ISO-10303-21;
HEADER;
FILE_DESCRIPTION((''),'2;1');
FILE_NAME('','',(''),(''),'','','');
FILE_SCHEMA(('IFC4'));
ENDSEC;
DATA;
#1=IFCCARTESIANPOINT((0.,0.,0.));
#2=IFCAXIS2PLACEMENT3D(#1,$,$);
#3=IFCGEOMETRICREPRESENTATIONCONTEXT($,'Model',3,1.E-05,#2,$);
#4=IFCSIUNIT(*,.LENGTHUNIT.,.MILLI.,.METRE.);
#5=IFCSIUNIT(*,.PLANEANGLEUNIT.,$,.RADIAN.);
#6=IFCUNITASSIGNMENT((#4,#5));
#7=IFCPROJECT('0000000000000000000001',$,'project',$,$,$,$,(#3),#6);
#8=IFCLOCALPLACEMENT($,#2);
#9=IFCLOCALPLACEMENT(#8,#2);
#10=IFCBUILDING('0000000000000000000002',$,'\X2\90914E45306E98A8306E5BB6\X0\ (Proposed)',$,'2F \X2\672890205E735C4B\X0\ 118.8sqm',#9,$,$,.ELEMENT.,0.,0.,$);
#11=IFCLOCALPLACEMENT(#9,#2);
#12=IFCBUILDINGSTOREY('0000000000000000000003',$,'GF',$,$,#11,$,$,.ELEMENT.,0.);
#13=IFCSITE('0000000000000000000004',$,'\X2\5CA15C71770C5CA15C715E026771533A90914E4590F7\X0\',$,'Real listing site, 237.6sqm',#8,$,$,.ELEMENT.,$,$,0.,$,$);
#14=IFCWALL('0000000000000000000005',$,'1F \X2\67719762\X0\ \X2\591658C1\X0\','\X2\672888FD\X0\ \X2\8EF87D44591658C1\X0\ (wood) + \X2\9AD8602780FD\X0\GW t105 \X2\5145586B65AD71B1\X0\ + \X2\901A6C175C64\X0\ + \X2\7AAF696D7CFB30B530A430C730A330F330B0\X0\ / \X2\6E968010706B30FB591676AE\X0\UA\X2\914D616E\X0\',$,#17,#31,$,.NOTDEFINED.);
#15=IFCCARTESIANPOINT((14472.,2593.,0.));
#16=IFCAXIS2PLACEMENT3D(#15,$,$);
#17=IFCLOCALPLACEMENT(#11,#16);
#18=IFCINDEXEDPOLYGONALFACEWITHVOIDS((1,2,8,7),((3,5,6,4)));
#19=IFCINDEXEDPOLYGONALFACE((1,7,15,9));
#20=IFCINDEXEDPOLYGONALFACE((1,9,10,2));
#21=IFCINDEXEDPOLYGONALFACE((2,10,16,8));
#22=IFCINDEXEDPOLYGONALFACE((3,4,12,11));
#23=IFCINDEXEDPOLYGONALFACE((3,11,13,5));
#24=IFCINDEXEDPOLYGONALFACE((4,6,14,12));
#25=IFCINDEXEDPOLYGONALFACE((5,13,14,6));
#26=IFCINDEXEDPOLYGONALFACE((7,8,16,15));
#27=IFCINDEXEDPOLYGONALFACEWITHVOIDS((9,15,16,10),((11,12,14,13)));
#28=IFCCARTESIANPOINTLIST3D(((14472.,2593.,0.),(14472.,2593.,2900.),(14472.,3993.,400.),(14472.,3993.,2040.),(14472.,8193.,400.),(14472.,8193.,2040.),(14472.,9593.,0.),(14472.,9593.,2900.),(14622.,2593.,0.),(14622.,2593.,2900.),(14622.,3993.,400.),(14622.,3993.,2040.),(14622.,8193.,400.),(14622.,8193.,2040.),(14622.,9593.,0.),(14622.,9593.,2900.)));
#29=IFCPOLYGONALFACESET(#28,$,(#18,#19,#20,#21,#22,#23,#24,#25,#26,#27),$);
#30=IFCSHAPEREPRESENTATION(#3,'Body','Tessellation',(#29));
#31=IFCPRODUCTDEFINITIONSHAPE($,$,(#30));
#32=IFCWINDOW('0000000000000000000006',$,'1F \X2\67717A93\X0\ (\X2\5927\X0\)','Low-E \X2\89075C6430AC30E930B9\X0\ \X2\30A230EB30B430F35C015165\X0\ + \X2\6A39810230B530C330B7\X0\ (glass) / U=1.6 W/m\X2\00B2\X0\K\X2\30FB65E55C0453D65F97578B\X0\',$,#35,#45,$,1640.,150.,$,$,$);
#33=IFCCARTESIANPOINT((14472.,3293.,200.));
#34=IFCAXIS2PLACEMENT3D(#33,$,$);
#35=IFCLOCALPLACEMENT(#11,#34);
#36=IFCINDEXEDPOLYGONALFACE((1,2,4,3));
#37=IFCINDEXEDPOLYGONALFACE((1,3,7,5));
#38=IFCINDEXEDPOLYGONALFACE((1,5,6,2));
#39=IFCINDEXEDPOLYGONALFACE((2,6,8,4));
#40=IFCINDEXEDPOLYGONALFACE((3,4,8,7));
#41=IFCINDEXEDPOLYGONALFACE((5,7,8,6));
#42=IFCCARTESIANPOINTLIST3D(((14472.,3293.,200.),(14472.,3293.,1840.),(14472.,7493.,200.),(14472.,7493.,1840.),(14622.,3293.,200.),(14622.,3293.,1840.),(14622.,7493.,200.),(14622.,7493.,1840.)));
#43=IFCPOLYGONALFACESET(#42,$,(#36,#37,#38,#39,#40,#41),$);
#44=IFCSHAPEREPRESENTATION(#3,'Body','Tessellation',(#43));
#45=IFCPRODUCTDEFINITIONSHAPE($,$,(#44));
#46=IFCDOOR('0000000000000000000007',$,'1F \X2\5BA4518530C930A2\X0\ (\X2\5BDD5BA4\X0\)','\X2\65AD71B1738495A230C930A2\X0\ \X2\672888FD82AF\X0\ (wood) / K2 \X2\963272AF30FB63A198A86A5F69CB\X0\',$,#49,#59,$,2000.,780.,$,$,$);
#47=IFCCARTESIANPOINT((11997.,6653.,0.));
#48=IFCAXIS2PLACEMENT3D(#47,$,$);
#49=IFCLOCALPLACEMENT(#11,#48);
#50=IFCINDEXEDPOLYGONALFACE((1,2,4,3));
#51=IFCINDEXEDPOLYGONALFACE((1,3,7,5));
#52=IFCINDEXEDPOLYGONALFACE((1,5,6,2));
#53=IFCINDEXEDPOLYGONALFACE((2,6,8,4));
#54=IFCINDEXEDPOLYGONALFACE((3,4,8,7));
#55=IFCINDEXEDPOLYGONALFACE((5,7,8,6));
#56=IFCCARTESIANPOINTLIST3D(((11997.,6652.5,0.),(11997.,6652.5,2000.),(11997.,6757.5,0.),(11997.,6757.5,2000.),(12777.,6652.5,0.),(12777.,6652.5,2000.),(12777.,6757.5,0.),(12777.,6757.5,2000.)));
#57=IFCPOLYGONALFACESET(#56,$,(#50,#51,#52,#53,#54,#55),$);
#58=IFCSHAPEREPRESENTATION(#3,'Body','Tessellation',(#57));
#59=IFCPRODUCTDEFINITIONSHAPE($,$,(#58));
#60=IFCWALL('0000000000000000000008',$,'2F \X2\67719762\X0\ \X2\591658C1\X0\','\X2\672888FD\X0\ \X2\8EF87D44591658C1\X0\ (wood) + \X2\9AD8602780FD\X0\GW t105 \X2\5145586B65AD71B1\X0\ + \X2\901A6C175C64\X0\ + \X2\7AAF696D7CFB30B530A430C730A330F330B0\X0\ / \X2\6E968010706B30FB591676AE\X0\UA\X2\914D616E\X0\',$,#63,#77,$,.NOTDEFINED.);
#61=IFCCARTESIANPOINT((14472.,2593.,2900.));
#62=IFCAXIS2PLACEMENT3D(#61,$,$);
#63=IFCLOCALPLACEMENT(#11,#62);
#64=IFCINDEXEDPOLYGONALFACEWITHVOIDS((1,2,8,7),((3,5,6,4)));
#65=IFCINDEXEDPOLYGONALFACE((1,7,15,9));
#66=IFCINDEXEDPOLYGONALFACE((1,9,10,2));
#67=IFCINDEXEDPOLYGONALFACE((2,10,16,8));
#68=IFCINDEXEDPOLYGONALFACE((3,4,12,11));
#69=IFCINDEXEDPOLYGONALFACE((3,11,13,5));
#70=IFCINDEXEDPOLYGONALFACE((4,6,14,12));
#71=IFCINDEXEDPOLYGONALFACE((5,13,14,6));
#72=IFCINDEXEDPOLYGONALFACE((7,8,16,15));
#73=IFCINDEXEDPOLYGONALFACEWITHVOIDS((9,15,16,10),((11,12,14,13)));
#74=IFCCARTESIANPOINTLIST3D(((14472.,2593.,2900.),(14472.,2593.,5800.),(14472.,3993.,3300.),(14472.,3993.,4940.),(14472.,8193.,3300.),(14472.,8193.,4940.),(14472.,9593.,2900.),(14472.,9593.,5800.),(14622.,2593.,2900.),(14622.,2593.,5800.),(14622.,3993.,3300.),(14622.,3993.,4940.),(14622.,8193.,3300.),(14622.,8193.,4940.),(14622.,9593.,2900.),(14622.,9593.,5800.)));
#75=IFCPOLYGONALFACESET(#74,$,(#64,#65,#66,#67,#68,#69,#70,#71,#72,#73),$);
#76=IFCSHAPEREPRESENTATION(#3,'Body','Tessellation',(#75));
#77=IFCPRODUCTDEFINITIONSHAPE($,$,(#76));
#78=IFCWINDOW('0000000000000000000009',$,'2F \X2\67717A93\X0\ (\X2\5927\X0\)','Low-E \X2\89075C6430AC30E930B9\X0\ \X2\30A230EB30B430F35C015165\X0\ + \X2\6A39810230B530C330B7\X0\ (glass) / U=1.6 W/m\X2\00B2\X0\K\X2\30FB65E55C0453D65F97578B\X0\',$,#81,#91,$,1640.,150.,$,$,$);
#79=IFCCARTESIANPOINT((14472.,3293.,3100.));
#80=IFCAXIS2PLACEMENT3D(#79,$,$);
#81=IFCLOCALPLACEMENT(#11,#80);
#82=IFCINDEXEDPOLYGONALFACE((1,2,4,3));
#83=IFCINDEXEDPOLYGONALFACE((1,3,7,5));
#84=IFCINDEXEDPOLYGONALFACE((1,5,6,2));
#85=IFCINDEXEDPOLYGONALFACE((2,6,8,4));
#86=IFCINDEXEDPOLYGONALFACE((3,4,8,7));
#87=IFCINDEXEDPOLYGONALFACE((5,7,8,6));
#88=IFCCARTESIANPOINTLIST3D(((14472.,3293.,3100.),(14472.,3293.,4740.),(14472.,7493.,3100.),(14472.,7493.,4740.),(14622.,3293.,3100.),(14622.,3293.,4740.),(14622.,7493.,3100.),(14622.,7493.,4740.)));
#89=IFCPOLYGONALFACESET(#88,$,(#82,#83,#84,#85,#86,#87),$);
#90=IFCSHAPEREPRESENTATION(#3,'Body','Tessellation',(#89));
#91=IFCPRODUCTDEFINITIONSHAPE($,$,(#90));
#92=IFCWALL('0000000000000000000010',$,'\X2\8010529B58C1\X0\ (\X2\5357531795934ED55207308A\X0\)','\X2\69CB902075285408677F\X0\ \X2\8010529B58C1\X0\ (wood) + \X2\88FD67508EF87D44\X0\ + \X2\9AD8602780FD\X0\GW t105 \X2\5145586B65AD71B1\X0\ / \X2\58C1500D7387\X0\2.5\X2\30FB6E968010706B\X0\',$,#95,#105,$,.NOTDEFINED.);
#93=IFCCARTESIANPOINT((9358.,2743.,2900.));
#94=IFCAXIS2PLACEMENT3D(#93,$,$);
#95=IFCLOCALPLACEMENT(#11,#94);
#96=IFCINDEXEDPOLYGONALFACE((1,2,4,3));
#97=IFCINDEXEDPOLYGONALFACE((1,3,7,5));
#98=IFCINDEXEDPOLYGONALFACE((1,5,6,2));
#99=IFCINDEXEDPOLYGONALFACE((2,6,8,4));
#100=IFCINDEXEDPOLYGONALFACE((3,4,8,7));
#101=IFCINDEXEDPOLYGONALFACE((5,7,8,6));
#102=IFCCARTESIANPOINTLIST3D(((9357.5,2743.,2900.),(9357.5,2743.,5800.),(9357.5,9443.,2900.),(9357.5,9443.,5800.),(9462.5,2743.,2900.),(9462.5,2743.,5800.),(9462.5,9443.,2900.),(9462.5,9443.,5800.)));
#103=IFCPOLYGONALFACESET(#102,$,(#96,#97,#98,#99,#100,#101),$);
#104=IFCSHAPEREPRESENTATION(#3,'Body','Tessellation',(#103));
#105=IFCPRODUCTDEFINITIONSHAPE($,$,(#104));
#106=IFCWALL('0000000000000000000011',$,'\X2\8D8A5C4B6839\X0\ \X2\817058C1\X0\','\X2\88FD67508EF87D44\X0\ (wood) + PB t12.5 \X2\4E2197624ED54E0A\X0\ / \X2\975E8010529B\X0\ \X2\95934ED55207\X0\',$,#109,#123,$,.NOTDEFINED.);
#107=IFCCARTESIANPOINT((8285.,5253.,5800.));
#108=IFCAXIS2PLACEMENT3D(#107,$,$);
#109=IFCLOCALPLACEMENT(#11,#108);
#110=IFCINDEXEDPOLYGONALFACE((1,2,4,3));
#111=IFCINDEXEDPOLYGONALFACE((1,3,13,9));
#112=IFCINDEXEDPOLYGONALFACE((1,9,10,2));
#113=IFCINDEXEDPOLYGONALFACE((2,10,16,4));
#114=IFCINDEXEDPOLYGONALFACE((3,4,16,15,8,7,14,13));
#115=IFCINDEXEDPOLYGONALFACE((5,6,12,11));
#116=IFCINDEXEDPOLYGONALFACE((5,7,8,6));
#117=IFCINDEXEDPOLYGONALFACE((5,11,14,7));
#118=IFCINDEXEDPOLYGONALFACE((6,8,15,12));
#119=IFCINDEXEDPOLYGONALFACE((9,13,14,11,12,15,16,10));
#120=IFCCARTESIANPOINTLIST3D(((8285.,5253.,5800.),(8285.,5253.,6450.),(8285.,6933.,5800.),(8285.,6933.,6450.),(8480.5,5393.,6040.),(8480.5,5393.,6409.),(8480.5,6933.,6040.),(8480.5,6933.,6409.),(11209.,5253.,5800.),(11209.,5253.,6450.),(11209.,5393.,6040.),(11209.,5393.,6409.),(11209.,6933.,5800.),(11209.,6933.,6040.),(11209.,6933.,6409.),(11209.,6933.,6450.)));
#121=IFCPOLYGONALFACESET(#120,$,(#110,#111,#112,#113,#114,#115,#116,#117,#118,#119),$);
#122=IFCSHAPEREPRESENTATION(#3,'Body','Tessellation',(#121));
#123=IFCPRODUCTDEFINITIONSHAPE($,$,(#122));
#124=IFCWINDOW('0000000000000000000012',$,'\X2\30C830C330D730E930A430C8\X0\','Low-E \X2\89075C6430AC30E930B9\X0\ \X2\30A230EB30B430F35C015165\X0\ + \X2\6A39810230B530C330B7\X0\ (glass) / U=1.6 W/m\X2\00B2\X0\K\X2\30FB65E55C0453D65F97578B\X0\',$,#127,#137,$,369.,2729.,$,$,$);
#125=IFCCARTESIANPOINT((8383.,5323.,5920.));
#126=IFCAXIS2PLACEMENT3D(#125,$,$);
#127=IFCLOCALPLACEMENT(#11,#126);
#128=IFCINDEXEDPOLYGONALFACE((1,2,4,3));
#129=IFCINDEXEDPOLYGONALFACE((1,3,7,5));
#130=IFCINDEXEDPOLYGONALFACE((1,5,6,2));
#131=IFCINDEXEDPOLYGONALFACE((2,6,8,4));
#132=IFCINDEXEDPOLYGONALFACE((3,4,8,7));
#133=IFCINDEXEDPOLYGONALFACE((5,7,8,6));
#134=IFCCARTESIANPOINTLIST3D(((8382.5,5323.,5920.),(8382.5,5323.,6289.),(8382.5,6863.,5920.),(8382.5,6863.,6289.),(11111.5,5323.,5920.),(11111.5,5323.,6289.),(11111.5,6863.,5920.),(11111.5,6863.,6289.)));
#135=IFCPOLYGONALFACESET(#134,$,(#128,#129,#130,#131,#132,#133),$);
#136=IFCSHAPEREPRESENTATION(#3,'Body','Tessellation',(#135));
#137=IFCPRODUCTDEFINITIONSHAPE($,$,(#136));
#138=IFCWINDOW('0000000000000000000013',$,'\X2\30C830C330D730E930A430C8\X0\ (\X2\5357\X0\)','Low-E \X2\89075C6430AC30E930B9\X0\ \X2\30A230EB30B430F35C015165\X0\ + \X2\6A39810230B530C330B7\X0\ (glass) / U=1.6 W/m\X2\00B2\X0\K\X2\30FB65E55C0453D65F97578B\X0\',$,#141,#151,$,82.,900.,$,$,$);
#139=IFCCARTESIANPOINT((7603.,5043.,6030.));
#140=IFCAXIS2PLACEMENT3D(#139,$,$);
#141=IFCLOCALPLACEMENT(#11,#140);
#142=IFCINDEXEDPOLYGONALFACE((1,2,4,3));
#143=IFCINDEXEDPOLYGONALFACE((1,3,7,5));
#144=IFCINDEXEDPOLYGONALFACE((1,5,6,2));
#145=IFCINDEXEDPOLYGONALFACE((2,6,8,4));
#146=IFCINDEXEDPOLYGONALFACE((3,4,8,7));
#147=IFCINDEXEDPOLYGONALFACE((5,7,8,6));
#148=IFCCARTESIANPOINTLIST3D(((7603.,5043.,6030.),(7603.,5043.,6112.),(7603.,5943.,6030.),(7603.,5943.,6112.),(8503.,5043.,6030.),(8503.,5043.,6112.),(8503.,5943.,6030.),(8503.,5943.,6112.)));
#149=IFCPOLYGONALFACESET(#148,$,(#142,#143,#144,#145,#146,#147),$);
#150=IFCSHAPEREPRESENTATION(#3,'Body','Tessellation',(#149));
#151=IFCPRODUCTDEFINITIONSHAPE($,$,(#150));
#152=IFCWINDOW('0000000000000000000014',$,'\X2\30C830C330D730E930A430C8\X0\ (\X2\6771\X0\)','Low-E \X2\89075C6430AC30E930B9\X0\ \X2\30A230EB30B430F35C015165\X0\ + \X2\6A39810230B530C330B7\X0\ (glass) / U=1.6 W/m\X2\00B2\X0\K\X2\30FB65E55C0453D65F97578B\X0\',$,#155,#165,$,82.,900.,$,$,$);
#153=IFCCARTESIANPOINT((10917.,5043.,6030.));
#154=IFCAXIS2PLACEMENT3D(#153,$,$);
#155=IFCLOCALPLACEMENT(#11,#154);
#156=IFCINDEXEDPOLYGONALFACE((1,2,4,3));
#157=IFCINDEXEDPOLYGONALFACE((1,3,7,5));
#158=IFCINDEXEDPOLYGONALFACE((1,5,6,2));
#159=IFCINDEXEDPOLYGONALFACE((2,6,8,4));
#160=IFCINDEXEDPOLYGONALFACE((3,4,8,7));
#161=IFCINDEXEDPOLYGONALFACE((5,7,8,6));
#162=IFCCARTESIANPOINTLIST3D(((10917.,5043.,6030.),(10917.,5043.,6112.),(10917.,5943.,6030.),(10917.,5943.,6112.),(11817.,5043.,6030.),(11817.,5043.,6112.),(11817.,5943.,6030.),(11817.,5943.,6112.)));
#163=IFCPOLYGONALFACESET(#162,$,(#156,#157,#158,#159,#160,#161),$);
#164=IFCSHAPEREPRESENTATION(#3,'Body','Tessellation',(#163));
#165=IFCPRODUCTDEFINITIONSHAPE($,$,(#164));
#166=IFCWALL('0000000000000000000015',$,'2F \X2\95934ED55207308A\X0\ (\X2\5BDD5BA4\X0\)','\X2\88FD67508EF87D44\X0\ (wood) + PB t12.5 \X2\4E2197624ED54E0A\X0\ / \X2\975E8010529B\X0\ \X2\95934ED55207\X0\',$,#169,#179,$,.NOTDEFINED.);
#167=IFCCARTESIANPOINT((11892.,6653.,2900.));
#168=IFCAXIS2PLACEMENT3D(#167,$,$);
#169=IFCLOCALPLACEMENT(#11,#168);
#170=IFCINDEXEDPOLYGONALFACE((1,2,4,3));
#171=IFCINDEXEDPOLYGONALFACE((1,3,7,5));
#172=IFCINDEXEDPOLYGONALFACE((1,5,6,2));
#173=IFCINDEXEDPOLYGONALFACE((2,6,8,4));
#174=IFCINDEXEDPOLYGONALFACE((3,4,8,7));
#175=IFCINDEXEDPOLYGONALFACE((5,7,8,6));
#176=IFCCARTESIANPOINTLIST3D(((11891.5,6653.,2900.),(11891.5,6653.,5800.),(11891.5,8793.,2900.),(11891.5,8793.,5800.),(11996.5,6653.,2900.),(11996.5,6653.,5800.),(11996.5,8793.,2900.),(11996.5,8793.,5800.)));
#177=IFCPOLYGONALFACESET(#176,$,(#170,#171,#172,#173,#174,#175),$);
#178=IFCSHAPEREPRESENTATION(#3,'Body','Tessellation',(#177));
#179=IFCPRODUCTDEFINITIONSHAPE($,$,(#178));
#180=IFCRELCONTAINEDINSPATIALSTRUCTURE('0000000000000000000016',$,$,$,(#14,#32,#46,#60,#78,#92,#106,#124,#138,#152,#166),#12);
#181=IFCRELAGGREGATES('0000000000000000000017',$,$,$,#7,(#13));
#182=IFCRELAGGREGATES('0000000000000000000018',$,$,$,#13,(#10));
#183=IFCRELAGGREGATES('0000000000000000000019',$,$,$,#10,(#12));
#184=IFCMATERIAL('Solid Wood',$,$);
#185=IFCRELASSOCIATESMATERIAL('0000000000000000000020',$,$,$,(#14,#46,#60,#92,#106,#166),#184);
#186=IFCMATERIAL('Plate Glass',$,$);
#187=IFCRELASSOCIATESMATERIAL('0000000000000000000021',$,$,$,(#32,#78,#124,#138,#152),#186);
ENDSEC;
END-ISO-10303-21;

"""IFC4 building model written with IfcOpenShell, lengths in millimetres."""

from ifc_helpers import new_model, si_unit, frame, frame_2d, origin, place, context, project, spatial, rectangle, extrude, material, element, fill, save


model = new_model("IFC4")

# Units and contexts
model_context = context("Model", 3, precision=1e-05, world=origin())
ifc_project = project(units=[si_unit("LENGTHUNIT", "METRE", prefix="MILLI"), si_unit("PLANEANGLEUNIT", "RADIAN")], contexts=[model_context])

# Site, building, storey
site_placement = place(None, origin())
site = spatial("IfcSite", under=ifc_project, at=site_placement, Name="岡山県岡山市東区邑久郷", ObjectType="Real listing site, 237.6sqm", CompositionType="ELEMENT", RefElevation=0.0)
building_placement = place(site_placement, origin())
building = spatial("IfcBuilding", under=site, at=building_placement, Name="邑久の風の家 (Proposed)", ObjectType="2F 木造平屋 118.8sqm", CompositionType="ELEMENT", ElevationOfRefHeight=0.0, ElevationOfTerrain=0.0)
storey_placement = place(building_placement, origin())
storey = spatial("IfcBuildingStorey", under=building, at=storey_placement, Name="GF", CompositionType="ELEMENT", Elevation=0.0)

# Wall, opening, window
ifc_material_1 = material(Name="Solid Wood")
wall_1_placement = place(storey_placement, frame((14472.0, 2593.0, 0.0)))
wall_1 = element("IfcWall", 1, at=wall_1_placement, inside=storey, material=ifc_material_1, Name="1F 東面 外壁", Description="木製 軸組外壁 (wood) + 高性能GW t105 充填断熱 + 通気層 + 窯業系サイディング / 準耐火・外皮UA配慮", PredefinedType="NOTDEFINED", context=model_context, shape_type="SweptSolid", body=[
    extrude(rectangle(XDim=150.0, YDim=7000.0, at=frame_2d((75.0, 3500.0))), frame((14472.0, 2593.0, 0.0)), (0.0, 0.0, 1.0), 2900.0),
])
opening_1_placement = place(storey_placement, frame((14472.0, 3293.0, 200.0)))
opening_1 = element("IfcOpeningElement", 2, at=opening_1_placement, cuts=wall_1, PredefinedType="NOTDEFINED", context=model_context, shape_type="SweptSolid", body=[
    extrude(rectangle(XDim=150.0, YDim=4200.0, at=frame_2d((75.0, 2100.0))), frame((14472.0, 3293.0, 200.0)), (0.0, 0.0, 1.0), 1640.0),
])
ifc_material_2 = material(Name="Plate Glass")
window_1_placement = place(storey_placement, frame((14472.0, 3293.0, 200.0)))
window_1 = element("IfcWindow", 3, at=window_1_placement, inside=storey, material=ifc_material_2, Name="1F 東窓 (大)", Description="Low-E 複層ガラス アルゴン封入 + 樹脂サッシ (glass) / U=1.6 W/m²K・日射取得型", OverallHeight=1640.0, OverallWidth=150.0, context=model_context, shape_type="SweptSolid", body=[
    extrude(rectangle(XDim=150.0, YDim=4200.0, at=frame_2d((75.0, 2100.0))), frame((14472.0, 3293.0, 200.0)), (0.0, 0.0, 1.0), 1640.0),
])
fill(opening_1, window_1)

# Door
door_1_placement = place(storey_placement, frame((11997.0, 6653.0, 0.0)))
element("IfcDoor", 4, at=door_1_placement, inside=storey, material=ifc_material_1, Name="1F 室内ドア (寝室)", Description="断熱玄関ドア 木製芯 (wood) / K2 防犯・採風機構", OverallHeight=2000.0, OverallWidth=780.0, context=model_context, shape_type="SweptSolid", body=[
    extrude(rectangle(XDim=780.0, YDim=105.0, at=frame_2d((390.0, 52.0))), frame((11997.0, 6653.0, 0.0)), (0.0, 0.0, 1.0), 2000.0),
])

# Wall, opening, window
wall_2_placement = place(storey_placement, frame((14472.0, 2593.0, 2900.0)))
wall_2 = element("IfcWall", 5, at=wall_2_placement, inside=storey, material=ifc_material_1, Name="2F 東面 外壁", Description="木製 軸組外壁 (wood) + 高性能GW t105 充填断熱 + 通気層 + 窯業系サイディング / 準耐火・外皮UA配慮", PredefinedType="NOTDEFINED", context=model_context, shape_type="SweptSolid", body=[
    extrude(rectangle(XDim=150.0, YDim=7000.0, at=frame_2d((75.0, 3500.0))), frame((14472.0, 2593.0, 2900.0)), (0.0, 0.0, 1.0), 2900.0),
])
opening_2_placement = place(storey_placement, frame((14472.0, 3293.0, 3100.0)))
opening_2 = element("IfcOpeningElement", 6, at=opening_2_placement, cuts=wall_2, PredefinedType="NOTDEFINED", context=model_context, shape_type="SweptSolid", body=[
    extrude(rectangle(XDim=150.0, YDim=4200.0, at=frame_2d((75.0, 2100.0))), frame((14472.0, 3293.0, 3100.0)), (0.0, 0.0, 1.0), 1640.0),
])
window_2_placement = place(storey_placement, frame((14472.0, 3293.0, 3100.0)))
window_2 = element("IfcWindow", 7, at=window_2_placement, inside=storey, material=ifc_material_2, Name="2F 東窓 (大)", Description="Low-E 複層ガラス アルゴン封入 + 樹脂サッシ (glass) / U=1.6 W/m²K・日射取得型", OverallHeight=1640.0, OverallWidth=150.0, context=model_context, shape_type="SweptSolid", body=[
    extrude(rectangle(XDim=150.0, YDim=4200.0, at=frame_2d((75.0, 2100.0))), frame((14472.0, 3293.0, 3100.0)), (0.0, 0.0, 1.0), 1640.0),
])
fill(opening_2, window_2)

# Wall
wall_3_placement = place(storey_placement, frame((9358.0, 2743.0, 2900.0)))
element("IfcWall", 8, at=wall_3_placement, inside=storey, material=ifc_material_1, Name="耐力壁 (南北間仕切り)", Description="構造用合板 耐力壁 (wood) + 製材軸組 + 高性能GW t105 充填断熱 / 壁倍率2.5・準耐火", PredefinedType="NOTDEFINED", context=model_context, shape_type="SweptSolid", body=[
    extrude(rectangle(XDim=105.0, YDim=6700.0, at=frame_2d((52.0, 3350.0))), frame((9358.0, 2743.0, 2900.0)), (0.0, 0.0, 1.0), 2900.0),
])

# Wall, openings, windows
wall_4_placement = place(storey_placement, frame((8285.0, 5253.0, 5800.0)))
wall_4 = element("IfcWall", 9, at=wall_4_placement, inside=storey, material=ifc_material_1, Name="越屋根 腰壁", Description="製材軸組 (wood) + PB t12.5 両面仕上 / 非耐力 間仕切", PredefinedType="NOTDEFINED", context=model_context, shape_type="SweptSolid", body=[
    extrude(rectangle(XDim=2924.0, YDim=1680.0, at=frame_2d((1462.0, 840.0))), frame((8285.0, 5253.0, 5800.0)), (0.0, 0.0, 1.0), 650.0),
])
opening_3_placement = place(storey_placement, frame((8383.0, 5323.0, 5920.0)))
opening_3 = element("IfcOpeningElement", 10, at=opening_3_placement, cuts=wall_4, PredefinedType="NOTDEFINED", context=model_context, shape_type="SweptSolid", body=[
    extrude(rectangle(XDim=2729.0, YDim=1540.0, at=frame_2d((1364.0, 770.0))), frame((8383.0, 5323.0, 5920.0)), (0.0, 0.0, 1.0), 369.0),
])
opening_4_placement = place(storey_placement, frame((7603.0, 5043.0, 6030.0)))
opening_4 = element("IfcOpeningElement", 11, at=opening_4_placement, cuts=wall_4, PredefinedType="NOTDEFINED", context=model_context, shape_type="SweptSolid", body=[
    extrude(rectangle(XDim=900.0, YDim=900.0, at=frame_2d((450.0, 450.0))), frame((7603.0, 5043.0, 6030.0)), (0.0, 0.0, 1.0), 82.0),
])
opening_5_placement = place(storey_placement, frame((10917.0, 5043.0, 6030.0)))
opening_5 = element("IfcOpeningElement", 12, at=opening_5_placement, cuts=wall_4, PredefinedType="NOTDEFINED", context=model_context, shape_type="SweptSolid", body=[
    extrude(rectangle(XDim=900.0, YDim=900.0, at=frame_2d((450.0, 450.0))), frame((10917.0, 5043.0, 6030.0)), (0.0, 0.0, 1.0), 82.0),
])
window_3_placement = place(storey_placement, frame((8383.0, 5323.0, 5920.0)))
window_3 = element("IfcWindow", 13, at=window_3_placement, inside=storey, material=ifc_material_2, Name="トップライト", Description="Low-E 複層ガラス アルゴン封入 + 樹脂サッシ (glass) / U=1.6 W/m²K・日射取得型", OverallHeight=369.0, OverallWidth=2729.0, context=model_context, shape_type="SweptSolid", body=[
    extrude(rectangle(XDim=2729.0, YDim=1540.0, at=frame_2d((1364.0, 770.0))), frame((8383.0, 5323.0, 5920.0)), (0.0, 0.0, 1.0), 369.0),
])
fill(opening_3, window_3)
window_4_placement = place(storey_placement, frame((7603.0, 5043.0, 6030.0)))
window_4 = element("IfcWindow", 14, at=window_4_placement, inside=storey, material=ifc_material_2, Name="トップライト (南)", Description="Low-E 複層ガラス アルゴン封入 + 樹脂サッシ (glass) / U=1.6 W/m²K・日射取得型", OverallHeight=82.0, OverallWidth=900.0, context=model_context, shape_type="SweptSolid", body=[
    extrude(rectangle(XDim=900.0, YDim=900.0, at=frame_2d((450.0, 450.0))), frame((7603.0, 5043.0, 6030.0)), (0.0, 0.0, 1.0), 82.0),
])
fill(opening_4, window_4)
window_5_placement = place(storey_placement, frame((10917.0, 5043.0, 6030.0)))
window_5 = element("IfcWindow", 15, at=window_5_placement, inside=storey, material=ifc_material_2, Name="トップライト (東)", Description="Low-E 複層ガラス アルゴン封入 + 樹脂サッシ (glass) / U=1.6 W/m²K・日射取得型", OverallHeight=82.0, OverallWidth=900.0, context=model_context, shape_type="SweptSolid", body=[
    extrude(rectangle(XDim=900.0, YDim=900.0, at=frame_2d((450.0, 450.0))), frame((10917.0, 5043.0, 6030.0)), (0.0, 0.0, 1.0), 82.0),
])
fill(opening_5, window_5)

# Wall
wall_5_placement = place(storey_placement, frame((11892.0, 6653.0, 2900.0)))
element("IfcWall", 16, at=wall_5_placement, inside=storey, material=ifc_material_1, Name="2F 間仕切り (寝室)", Description="製材軸組 (wood) + PB t12.5 両面仕上 / 非耐力 間仕切", PredefinedType="NOTDEFINED", context=model_context, shape_type="SweptSolid", body=[
    extrude(rectangle(XDim=105.0, YDim=2140.0, at=frame_2d((52.0, 1070.0))), frame((11892.0, 6653.0, 2900.0)), (0.0, 0.0, 1.0), 2900.0),
])

save(model, "model.ifc")
